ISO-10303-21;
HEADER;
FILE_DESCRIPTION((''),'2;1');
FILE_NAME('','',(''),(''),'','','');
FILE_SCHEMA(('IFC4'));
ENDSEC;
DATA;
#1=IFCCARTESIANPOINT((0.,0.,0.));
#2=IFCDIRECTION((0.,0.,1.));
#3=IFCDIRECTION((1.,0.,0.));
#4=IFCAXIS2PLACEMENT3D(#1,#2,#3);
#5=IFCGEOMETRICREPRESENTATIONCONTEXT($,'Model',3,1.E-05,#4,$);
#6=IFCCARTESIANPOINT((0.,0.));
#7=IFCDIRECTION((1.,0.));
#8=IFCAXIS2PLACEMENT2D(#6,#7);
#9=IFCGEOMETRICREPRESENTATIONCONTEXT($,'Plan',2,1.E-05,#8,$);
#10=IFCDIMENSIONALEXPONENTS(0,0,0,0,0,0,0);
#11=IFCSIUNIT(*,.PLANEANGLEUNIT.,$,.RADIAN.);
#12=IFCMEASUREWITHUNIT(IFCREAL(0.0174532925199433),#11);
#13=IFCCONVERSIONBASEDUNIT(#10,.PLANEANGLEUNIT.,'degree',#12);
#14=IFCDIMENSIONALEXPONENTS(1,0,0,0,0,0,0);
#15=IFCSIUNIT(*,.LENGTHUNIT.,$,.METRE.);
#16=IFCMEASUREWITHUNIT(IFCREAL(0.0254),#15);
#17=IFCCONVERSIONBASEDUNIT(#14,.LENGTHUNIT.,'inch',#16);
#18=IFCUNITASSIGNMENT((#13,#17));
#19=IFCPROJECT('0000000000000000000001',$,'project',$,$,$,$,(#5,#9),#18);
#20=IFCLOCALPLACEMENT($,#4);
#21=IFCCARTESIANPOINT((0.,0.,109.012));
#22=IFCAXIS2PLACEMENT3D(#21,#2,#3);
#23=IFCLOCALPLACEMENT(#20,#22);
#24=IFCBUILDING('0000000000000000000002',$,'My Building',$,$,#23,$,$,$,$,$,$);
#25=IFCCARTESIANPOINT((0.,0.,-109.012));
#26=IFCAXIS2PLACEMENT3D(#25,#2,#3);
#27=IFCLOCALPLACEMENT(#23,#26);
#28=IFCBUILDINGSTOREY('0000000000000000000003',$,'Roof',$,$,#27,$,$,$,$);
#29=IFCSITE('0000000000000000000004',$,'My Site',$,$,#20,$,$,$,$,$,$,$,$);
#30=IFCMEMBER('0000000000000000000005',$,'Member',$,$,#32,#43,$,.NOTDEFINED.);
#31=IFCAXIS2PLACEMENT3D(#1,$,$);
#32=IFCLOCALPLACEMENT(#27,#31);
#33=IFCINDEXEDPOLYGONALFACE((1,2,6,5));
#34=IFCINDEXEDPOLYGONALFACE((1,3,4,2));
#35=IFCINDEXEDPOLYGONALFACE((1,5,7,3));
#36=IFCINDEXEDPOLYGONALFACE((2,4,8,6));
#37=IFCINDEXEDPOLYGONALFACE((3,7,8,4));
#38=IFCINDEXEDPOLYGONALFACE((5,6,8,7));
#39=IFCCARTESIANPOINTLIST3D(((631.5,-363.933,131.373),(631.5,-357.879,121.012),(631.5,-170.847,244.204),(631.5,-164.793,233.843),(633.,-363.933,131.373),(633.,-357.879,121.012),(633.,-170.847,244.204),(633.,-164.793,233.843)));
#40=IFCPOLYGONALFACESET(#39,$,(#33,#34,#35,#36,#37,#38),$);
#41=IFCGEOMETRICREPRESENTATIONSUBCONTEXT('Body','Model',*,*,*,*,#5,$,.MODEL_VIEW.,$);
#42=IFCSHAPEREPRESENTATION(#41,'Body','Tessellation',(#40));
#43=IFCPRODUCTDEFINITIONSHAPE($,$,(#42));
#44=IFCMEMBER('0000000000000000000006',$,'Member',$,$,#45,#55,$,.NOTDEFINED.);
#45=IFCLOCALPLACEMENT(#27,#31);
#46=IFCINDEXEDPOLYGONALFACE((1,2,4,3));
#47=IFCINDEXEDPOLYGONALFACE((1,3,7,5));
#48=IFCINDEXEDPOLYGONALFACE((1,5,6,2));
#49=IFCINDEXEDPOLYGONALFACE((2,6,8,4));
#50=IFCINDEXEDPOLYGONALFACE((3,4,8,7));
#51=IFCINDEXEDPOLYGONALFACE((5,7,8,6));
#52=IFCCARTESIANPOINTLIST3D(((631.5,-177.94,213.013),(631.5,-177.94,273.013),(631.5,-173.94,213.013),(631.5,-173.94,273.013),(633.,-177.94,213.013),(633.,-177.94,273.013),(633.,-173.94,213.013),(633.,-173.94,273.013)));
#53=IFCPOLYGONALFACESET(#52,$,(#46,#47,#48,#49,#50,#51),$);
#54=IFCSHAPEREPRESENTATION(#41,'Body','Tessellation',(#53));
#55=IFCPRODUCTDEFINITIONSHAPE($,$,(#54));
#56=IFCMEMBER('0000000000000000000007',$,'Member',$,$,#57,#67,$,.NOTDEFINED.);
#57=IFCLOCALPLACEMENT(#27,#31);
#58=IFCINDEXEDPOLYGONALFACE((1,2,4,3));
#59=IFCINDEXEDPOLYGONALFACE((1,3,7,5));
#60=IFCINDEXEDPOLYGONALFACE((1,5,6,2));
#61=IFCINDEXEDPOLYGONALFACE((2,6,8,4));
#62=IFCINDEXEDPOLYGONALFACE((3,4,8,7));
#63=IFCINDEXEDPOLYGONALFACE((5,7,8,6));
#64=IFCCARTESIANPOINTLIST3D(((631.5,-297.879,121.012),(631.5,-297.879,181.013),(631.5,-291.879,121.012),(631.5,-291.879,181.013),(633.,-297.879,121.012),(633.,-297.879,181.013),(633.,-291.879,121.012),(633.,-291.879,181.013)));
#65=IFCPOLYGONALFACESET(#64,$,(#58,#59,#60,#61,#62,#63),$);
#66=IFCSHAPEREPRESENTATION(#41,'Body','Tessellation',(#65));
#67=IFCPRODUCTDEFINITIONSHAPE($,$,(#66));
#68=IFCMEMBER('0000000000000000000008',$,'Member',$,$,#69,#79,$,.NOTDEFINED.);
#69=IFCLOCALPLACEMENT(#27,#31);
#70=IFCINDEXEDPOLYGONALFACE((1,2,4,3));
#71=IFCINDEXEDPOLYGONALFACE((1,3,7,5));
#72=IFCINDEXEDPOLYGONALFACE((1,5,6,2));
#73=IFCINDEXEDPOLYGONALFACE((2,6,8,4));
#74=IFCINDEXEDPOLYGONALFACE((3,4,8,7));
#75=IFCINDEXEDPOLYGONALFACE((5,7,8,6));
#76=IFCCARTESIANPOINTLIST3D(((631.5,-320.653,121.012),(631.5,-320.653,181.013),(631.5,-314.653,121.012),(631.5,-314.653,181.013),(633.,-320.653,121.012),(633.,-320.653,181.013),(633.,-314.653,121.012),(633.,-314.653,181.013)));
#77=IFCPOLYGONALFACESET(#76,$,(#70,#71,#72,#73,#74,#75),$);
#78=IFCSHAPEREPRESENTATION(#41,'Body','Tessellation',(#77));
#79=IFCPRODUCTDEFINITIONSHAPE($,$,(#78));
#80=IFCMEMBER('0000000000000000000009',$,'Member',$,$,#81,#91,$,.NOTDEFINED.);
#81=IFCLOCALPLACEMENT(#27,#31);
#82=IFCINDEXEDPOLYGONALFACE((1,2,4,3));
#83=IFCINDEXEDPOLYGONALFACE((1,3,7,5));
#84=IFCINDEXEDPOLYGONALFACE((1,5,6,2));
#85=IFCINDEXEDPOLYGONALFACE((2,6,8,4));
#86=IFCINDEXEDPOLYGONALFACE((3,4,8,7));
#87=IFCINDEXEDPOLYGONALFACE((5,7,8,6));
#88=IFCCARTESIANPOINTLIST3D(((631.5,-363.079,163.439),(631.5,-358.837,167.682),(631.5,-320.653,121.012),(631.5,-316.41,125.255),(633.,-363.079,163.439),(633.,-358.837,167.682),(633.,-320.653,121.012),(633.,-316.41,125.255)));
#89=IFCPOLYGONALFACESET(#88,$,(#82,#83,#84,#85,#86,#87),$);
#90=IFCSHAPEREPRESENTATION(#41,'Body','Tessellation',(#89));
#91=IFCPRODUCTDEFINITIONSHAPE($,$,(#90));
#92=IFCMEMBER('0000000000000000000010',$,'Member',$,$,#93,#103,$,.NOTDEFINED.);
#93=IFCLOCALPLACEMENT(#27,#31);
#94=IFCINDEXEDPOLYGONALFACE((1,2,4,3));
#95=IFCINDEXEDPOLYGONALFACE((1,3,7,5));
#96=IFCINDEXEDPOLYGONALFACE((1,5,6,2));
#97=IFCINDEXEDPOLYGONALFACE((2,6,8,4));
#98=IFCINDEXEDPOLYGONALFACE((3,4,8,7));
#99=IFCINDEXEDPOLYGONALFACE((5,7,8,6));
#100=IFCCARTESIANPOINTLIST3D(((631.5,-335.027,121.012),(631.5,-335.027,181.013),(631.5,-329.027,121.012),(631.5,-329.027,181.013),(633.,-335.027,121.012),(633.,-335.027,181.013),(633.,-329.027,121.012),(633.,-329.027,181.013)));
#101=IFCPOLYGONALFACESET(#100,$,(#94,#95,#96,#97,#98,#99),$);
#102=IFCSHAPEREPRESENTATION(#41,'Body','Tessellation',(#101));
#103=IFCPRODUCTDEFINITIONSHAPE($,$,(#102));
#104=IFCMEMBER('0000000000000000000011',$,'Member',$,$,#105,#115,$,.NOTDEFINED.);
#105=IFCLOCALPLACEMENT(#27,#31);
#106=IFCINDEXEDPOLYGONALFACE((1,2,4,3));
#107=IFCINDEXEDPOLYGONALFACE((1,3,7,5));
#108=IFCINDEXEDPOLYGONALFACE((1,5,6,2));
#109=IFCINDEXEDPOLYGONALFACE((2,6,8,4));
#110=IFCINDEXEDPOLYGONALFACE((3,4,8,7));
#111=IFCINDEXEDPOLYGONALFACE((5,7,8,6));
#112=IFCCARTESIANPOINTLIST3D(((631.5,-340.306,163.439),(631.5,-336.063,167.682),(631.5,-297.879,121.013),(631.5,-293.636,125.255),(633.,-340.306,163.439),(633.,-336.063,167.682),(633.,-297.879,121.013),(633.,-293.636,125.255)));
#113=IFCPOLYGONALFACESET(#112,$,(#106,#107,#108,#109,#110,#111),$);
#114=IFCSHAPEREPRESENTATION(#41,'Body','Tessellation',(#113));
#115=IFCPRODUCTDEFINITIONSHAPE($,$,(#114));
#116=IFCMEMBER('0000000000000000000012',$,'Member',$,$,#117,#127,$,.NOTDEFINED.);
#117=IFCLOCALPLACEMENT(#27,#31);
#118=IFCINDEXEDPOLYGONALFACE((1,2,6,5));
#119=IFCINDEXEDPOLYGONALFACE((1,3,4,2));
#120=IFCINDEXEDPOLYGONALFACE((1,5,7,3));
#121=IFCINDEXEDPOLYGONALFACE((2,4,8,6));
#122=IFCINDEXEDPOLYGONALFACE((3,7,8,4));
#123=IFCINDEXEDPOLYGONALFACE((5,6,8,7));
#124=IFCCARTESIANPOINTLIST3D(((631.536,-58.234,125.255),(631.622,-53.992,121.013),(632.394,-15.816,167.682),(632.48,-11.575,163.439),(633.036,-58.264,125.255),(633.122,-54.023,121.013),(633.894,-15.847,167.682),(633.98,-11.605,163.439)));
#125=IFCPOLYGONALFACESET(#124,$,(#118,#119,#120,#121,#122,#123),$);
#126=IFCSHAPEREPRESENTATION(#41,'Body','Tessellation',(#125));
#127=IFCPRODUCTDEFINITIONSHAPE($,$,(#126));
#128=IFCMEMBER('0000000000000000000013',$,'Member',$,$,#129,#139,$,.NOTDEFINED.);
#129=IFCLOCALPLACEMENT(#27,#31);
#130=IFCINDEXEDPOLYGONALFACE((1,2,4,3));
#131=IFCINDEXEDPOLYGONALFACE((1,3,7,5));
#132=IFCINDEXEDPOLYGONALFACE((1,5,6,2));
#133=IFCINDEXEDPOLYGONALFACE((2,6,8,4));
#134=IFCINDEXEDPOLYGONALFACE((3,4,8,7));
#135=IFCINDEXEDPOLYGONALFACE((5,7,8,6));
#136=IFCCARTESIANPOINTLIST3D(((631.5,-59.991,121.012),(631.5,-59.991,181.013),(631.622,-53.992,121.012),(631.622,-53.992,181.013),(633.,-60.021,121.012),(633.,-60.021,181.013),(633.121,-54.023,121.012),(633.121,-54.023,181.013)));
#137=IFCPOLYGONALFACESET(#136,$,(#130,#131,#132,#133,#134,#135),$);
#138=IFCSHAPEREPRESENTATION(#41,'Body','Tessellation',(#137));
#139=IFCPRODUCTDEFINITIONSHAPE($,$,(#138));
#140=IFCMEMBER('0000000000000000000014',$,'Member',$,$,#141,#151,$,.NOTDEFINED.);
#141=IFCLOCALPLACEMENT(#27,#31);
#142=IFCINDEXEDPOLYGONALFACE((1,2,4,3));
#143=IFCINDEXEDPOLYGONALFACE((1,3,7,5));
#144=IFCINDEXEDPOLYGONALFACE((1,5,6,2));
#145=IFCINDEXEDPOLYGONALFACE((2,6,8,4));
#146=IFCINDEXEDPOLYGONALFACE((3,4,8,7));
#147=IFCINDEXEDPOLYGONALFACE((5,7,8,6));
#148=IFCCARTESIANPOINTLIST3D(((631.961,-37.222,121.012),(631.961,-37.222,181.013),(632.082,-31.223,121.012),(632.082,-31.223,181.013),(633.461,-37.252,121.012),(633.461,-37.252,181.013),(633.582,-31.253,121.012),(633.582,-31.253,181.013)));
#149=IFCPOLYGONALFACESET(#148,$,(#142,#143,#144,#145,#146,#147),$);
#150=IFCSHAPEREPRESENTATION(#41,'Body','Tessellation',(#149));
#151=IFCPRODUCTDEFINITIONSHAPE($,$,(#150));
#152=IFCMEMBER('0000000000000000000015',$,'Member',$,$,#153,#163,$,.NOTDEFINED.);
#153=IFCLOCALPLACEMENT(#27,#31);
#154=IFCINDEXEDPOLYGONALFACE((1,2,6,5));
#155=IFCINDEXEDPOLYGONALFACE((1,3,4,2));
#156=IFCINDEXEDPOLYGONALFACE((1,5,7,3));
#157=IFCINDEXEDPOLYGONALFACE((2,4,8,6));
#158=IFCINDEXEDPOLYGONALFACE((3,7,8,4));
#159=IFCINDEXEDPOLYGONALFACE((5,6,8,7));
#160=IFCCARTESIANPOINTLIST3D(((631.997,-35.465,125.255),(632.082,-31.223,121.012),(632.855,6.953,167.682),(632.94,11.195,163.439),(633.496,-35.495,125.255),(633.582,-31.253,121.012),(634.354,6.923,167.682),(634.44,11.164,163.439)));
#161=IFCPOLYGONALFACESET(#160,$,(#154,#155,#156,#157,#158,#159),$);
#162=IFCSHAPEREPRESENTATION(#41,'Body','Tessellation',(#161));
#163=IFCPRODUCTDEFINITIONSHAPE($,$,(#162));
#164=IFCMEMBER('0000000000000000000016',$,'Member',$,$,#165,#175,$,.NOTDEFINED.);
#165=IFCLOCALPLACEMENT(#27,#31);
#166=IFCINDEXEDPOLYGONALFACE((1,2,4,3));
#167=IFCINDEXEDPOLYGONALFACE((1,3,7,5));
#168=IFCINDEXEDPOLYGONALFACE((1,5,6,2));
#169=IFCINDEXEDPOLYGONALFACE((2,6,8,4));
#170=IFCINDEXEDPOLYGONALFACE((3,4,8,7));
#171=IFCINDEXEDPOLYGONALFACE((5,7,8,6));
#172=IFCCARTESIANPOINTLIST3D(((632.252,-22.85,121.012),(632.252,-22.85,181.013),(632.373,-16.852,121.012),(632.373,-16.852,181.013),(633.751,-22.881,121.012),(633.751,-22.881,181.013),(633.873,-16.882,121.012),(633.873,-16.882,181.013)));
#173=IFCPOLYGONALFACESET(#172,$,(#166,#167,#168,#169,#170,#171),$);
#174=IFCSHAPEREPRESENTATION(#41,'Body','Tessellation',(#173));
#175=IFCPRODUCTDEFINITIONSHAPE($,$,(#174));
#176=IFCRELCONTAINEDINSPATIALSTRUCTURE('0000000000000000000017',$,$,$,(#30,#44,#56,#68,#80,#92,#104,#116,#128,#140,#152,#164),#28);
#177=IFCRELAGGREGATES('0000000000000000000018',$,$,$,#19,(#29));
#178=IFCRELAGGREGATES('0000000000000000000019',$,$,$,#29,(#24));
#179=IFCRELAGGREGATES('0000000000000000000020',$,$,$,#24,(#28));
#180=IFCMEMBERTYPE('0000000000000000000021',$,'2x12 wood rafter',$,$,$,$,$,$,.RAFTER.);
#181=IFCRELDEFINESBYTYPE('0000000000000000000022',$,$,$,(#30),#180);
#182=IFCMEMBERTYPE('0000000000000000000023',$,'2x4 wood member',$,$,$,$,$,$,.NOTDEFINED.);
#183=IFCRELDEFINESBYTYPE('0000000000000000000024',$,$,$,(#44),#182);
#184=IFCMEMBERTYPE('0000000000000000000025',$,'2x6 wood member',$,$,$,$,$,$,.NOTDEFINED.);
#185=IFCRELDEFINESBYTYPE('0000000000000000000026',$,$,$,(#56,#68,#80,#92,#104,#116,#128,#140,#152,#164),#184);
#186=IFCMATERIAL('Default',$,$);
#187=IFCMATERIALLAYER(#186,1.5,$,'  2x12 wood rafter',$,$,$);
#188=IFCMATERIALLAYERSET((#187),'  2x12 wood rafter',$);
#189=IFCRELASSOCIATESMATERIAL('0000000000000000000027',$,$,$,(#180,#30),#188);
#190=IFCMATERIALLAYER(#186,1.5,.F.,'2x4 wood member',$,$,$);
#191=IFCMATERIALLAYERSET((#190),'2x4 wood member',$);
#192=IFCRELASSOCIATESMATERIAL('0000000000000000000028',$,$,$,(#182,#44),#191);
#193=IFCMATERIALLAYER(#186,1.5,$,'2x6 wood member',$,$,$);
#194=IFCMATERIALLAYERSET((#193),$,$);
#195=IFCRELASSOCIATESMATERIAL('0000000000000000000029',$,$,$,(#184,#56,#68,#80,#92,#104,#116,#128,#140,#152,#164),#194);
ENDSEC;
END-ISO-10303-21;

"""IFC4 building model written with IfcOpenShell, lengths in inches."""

from ifc_helpers import new_model, entity, si_unit, converted_unit, frame, origin_with_axes, origin_2d_with_axis, place, context, subcontext, project, spatial, indexed_curve, outline, extrude, material, layer, layer_set, layer_usage, type_object, element, save


model = new_model("IFC4")

# Units and contexts
model_context = context("Model", 3, precision=1e-05, world=origin_with_axes())
plan_context = context("Plan", 2, precision=1e-05, world=origin_2d_with_axis())
body_context = subcontext(model_context, "Body", "Model", "MODEL_VIEW")
ifc_project = project(units=[converted_unit("PLANEANGLEUNIT", "degree", entity("IfcReal", 0.0174532925199433), si_unit("PLANEANGLEUNIT", "RADIAN"), dimensions=[0, 0, 0, 0, 0, 0, 0]), converted_unit("LENGTHUNIT", "inch", entity("IfcReal", 0.0254), si_unit("LENGTHUNIT", "METRE"), dimensions=[1, 0, 0, 0, 0, 0, 0])], contexts=[model_context, plan_context])

# Site, building, storey
site_placement = place(None, origin_with_axes())
site = spatial("IfcSite", under=ifc_project, at=site_placement, Name="My Site")
building_placement = place(site_placement, frame((0.0, 0.0, 109.012), z_axis=(0.0, 0.0, 1.0), x_axis=(1.0, 0.0, 0.0)))
building = spatial("IfcBuilding", under=site, at=building_placement, Name="My Building")
storey_placement = place(building_placement, frame((0.0, 0.0, -109.012), z_axis=(0.0, 0.0, 1.0), x_axis=(1.0, 0.0, 0.0)))
storey = spatial("IfcBuildingStorey", under=building, at=storey_placement, Name="Roof")

# Members
ifc_material = material(Name="Default")
ifc_layer_1 = layer(ifc_material, 1.5, Name="  2x12 wood rafter")
ifc_layer_set_1 = layer_set([ifc_layer_1], Name="  2x12 wood rafter")
ifc_layer_usage_1 = layer_usage(ifc_layer_set_1, "AXIS2", "POSITIVE", 0.0)
member_type_1 = type_object("IfcMemberType", Name="2x12 wood rafter", PredefinedType="RAFTER", material=ifc_layer_set_1)
member_1_placement = place(storey_placement, frame((633.0, -357.879, 121.012), z_axis=(0.0, -0.504528, 0.863396), x_axis=(0.000001, 0.863396, 0.504528)))
element("IfcMember", 1, at=member_1_placement, inside=storey, type_object=member_type_1, material=ifc_layer_usage_1, Name="Member", PredefinedType="NOTDEFINED", context=body_context, shape_type="SweptSolid", body=[
    extrude(outline(indexed_curve([(0.0, 0.0), (0.0, 1.5), (223.636, 1.5), (223.636, 0.0), (0.0, 0.0)], self_intersect=False)), origin_with_axes(), (0.0, 0.0, 1.0), 12.0),
])
ifc_layer_2 = layer(ifc_material, 1.5, ventilated=False, Name="2x4 wood member")
ifc_layer_set_2 = layer_set([ifc_layer_2], Name="2x4 wood member")
ifc_layer_usage_2 = layer_usage(ifc_layer_set_2, "AXIS2", "POSITIVE", 0.0)
member_type_2 = type_object("IfcMemberType", Name="2x4 wood member", PredefinedType="NOTDEFINED", material=ifc_layer_set_2)
member_2_placement = place(storey_placement, frame((633.0, -173.94, 213.013), z_axis=(0.0, -1.0, 0.0), x_axis=(0.0, 0.0, 1.0)))
element("IfcMember", 2, at=member_2_placement, inside=storey, type_object=member_type_2, material=ifc_layer_usage_2, Name="Member", PredefinedType="NOTDEFINED", context=body_context, shape_type="SweptSolid", body=[
    extrude(outline(indexed_curve([(0.0, 0.0), (0.0, 1.5), (60.0, 1.5), (60.0, 0.0), (0.0, 0.0)], self_intersect=False)), origin_with_axes(), (0.0, 0.0, 1.0), 4.0),
])

# Members
ifc_layer_3 = layer(ifc_material, 1.5, Name="2x6 wood member")
ifc_layer_set_3 = layer_set([ifc_layer_3])
ifc_layer_usage_3 = layer_usage(ifc_layer_set_3, "AXIS2", "POSITIVE", 0.0)
member_type_3 = type_object("IfcMemberType", Name="2x6 wood member", PredefinedType="NOTDEFINED", material=ifc_layer_set_3)
member_3_placement = place(storey_placement, frame((633.0, -291.879, 121.012), z_axis=(0.0, -1.0, 0.0), x_axis=(0.0, 0.0, 1.0)))
element("IfcMember", 3, at=member_3_placement, inside=storey, type_object=member_type_3, material=ifc_layer_usage_3, Name="Member", PredefinedType="NOTDEFINED", context=body_context, shape_type="SweptSolid", body=[
    extrude(outline(indexed_curve([(0.0, 0.0), (0.0, 1.5), (60.0, 1.5), (60.0, 0.0), (0.0, 0.0)], self_intersect=False)), origin_with_axes(), (0.0, 0.0, 1.0), 6.0),
])
ifc_layer_usage_4 = layer_usage(ifc_layer_set_3, "AXIS2", "POSITIVE", 0.0)
member_4_placement = place(storey_placement, frame((633.0, -314.653, 121.012), z_axis=(0.0, -1.0, 0.0), x_axis=(0.0, 0.0, 1.0)))
element("IfcMember", 4, at=member_4_placement, inside=storey, type_object=member_type_3, material=ifc_layer_usage_4, Name="Member", PredefinedType="NOTDEFINED", context=body_context, shape_type="SweptSolid", body=[
    extrude(outline(indexed_curve([(0.0, 0.0), (0.0, 1.5), (60.0, 1.5), (60.0, 0.0), (0.0, 0.0)], self_intersect=False)), origin_with_axes(), (0.0, 0.0, 1.0), 6.0),
])
ifc_layer_usage_5 = layer_usage(ifc_layer_set_3, "AXIS2", "POSITIVE", 0.0)
member_5_placement = place(storey_placement, frame((633.0, -316.41, 125.255), z_axis=(0.0, -0.707107, -0.707107), x_axis=(0.0, -0.707107, 0.707107)))
element("IfcMember", 5, at=member_5_placement, inside=storey, type_object=member_type_3, material=ifc_layer_usage_5, Name="Member", PredefinedType="NOTDEFINED", context=body_context, shape_type="SweptSolid", body=[
    extrude(outline(indexed_curve([(0.0, 0.0), (0.0, 1.5), (60.0, 1.5), (60.0, 0.0), (0.0, 0.0)], self_intersect=False)), origin_with_axes(), (0.0, 0.0, 1.0), 6.0),
])
ifc_layer_usage_6 = layer_usage(ifc_layer_set_3, "AXIS2", "POSITIVE", 0.0)
member_6_placement = place(storey_placement, frame((633.0, -329.027, 121.012), z_axis=(0.0, -1.0, 0.0), x_axis=(0.0, 0.0, 1.0)))
element("IfcMember", 6, at=member_6_placement, inside=storey, type_object=member_type_3, material=ifc_layer_usage_6, Name="Member", PredefinedType="NOTDEFINED", context=body_context, shape_type="SweptSolid", body=[
    extrude(outline(indexed_curve([(0.0, 0.0), (0.0, 1.5), (60.0, 1.5), (60.0, 0.0), (0.0, 0.0)], self_intersect=False)), origin_with_axes(), (0.0, 0.0, 1.0), 6.0),
])
ifc_layer_usage_7 = layer_usage(ifc_layer_set_3, "AXIS2", "POSITIVE", 0.0)
member_7_placement = place(storey_placement, frame((633.0, -293.636, 125.255), z_axis=(0.0, -0.707107, -0.707107), x_axis=(0.0, -0.707107, 0.707107)))
element("IfcMember", 7, at=member_7_placement, inside=storey, type_object=member_type_3, material=ifc_layer_usage_7, Name="Member", PredefinedType="NOTDEFINED", context=body_context, shape_type="SweptSolid", body=[
    extrude(outline(indexed_curve([(0.0, 0.0), (0.0, 1.5), (60.0, 1.5), (60.0, 0.0), (0.0, 0.0)], self_intersect=False)), origin_with_axes(), (0.0, 0.0, 1.0), 6.0),
])
ifc_layer_usage_8 = layer_usage(ifc_layer_set_3, "AXIS2", "POSITIVE", 0.0)
member_8_placement = place(storey_placement, frame((631.536, -58.234, 125.255), z_axis=(0.0143, 0.706962, -0.707107), x_axis=(0.0143, 0.706962, 0.707107)))
element("IfcMember", 8, at=member_8_placement, inside=storey, type_object=member_type_3, material=ifc_layer_usage_8, Name="Member", PredefinedType="NOTDEFINED", context=body_context, shape_type="SweptSolid", body=[
    extrude(outline(indexed_curve([(0.0, 0.0), (0.0, 1.5), (60.0, 1.5), (60.0, 0.0), (0.0, 0.0)], self_intersect=False)), origin_with_axes(), (0.0, 0.0, 1.0), 6.0),
])
ifc_layer_usage_9 = layer_usage(ifc_layer_set_3, "AXIS2", "POSITIVE", 0.0)
member_9_placement = place(storey_placement, frame((631.5, -59.991, 121.012), z_axis=(0.020224, 0.999795, 0.0), x_axis=(0.0, 0.0, 1.0)))
element("IfcMember", 9, at=member_9_placement, inside=storey, type_object=member_type_3, material=ifc_layer_usage_9, Name="Member", PredefinedType="NOTDEFINED", context=body_context, shape_type="SweptSolid", body=[
    extrude(outline(indexed_curve([(0.0, 0.0), (0.0, 1.5), (60.0, 1.5), (60.0, 0.0), (0.0, 0.0)], self_intersect=False)), origin_with_axes(), (0.0, 0.0, 1.0), 6.0),
])
ifc_layer_usage_10 = layer_usage(ifc_layer_set_3, "AXIS2", "POSITIVE", 0.0)
member_10_placement = place(storey_placement, frame((631.961, -37.222, 121.012), z_axis=(0.020224, 0.999795, 0.0), x_axis=(0.0, 0.0, 1.0)))
element("IfcMember", 10, at=member_10_placement, inside=storey, type_object=member_type_3, material=ifc_layer_usage_10, Name="Member", PredefinedType="NOTDEFINED", context=body_context, shape_type="SweptSolid", body=[
    extrude(outline(indexed_curve([(0.0, 0.0), (0.0, 1.5), (60.0, 1.5), (60.0, 0.0), (0.0, 0.0)], self_intersect=False)), origin_with_axes(), (0.0, 0.0, 1.0), 6.0),
])
ifc_layer_usage_11 = layer_usage(ifc_layer_set_3, "AXIS2", "POSITIVE", 0.0)
member_11_placement = place(storey_placement, frame((631.997, -35.465, 125.255), z_axis=(0.0143, 0.706962, -0.707107), x_axis=(0.0143, 0.706962, 0.707107)))
element("IfcMember", 11, at=member_11_placement, inside=storey, type_object=member_type_3, material=ifc_layer_usage_11, Name="Member", PredefinedType="NOTDEFINED", context=body_context, shape_type="SweptSolid", body=[
    extrude(outline(indexed_curve([(0.0, 0.0), (0.0, 1.5), (60.0, 1.5), (60.0, 0.0), (0.0, 0.0)], self_intersect=False)), origin_with_axes(), (0.0, 0.0, 1.0), 6.0),
])
ifc_layer_usage_12 = layer_usage(ifc_layer_set_3, "AXIS2", "POSITIVE", 0.0)
member_12_placement = place(storey_placement, frame((632.252, -22.85, 121.012), z_axis=(0.020224, 0.999795, 0.0), x_axis=(0.0, 0.0, 1.0)))
element("IfcMember", 12, at=member_12_placement, inside=storey, type_object=member_type_3, material=ifc_layer_usage_12, Name="Member", PredefinedType="NOTDEFINED", context=body_context, shape_type="SweptSolid", body=[
    extrude(outline(indexed_curve([(0.0, 0.0), (0.0, 1.5), (60.0, 1.5), (60.0, 0.0), (0.0, 0.0)], self_intersect=False)), origin_with_axes(), (0.0, 0.0, 1.0), 6.0),
])

save(model, "model.ifc")
